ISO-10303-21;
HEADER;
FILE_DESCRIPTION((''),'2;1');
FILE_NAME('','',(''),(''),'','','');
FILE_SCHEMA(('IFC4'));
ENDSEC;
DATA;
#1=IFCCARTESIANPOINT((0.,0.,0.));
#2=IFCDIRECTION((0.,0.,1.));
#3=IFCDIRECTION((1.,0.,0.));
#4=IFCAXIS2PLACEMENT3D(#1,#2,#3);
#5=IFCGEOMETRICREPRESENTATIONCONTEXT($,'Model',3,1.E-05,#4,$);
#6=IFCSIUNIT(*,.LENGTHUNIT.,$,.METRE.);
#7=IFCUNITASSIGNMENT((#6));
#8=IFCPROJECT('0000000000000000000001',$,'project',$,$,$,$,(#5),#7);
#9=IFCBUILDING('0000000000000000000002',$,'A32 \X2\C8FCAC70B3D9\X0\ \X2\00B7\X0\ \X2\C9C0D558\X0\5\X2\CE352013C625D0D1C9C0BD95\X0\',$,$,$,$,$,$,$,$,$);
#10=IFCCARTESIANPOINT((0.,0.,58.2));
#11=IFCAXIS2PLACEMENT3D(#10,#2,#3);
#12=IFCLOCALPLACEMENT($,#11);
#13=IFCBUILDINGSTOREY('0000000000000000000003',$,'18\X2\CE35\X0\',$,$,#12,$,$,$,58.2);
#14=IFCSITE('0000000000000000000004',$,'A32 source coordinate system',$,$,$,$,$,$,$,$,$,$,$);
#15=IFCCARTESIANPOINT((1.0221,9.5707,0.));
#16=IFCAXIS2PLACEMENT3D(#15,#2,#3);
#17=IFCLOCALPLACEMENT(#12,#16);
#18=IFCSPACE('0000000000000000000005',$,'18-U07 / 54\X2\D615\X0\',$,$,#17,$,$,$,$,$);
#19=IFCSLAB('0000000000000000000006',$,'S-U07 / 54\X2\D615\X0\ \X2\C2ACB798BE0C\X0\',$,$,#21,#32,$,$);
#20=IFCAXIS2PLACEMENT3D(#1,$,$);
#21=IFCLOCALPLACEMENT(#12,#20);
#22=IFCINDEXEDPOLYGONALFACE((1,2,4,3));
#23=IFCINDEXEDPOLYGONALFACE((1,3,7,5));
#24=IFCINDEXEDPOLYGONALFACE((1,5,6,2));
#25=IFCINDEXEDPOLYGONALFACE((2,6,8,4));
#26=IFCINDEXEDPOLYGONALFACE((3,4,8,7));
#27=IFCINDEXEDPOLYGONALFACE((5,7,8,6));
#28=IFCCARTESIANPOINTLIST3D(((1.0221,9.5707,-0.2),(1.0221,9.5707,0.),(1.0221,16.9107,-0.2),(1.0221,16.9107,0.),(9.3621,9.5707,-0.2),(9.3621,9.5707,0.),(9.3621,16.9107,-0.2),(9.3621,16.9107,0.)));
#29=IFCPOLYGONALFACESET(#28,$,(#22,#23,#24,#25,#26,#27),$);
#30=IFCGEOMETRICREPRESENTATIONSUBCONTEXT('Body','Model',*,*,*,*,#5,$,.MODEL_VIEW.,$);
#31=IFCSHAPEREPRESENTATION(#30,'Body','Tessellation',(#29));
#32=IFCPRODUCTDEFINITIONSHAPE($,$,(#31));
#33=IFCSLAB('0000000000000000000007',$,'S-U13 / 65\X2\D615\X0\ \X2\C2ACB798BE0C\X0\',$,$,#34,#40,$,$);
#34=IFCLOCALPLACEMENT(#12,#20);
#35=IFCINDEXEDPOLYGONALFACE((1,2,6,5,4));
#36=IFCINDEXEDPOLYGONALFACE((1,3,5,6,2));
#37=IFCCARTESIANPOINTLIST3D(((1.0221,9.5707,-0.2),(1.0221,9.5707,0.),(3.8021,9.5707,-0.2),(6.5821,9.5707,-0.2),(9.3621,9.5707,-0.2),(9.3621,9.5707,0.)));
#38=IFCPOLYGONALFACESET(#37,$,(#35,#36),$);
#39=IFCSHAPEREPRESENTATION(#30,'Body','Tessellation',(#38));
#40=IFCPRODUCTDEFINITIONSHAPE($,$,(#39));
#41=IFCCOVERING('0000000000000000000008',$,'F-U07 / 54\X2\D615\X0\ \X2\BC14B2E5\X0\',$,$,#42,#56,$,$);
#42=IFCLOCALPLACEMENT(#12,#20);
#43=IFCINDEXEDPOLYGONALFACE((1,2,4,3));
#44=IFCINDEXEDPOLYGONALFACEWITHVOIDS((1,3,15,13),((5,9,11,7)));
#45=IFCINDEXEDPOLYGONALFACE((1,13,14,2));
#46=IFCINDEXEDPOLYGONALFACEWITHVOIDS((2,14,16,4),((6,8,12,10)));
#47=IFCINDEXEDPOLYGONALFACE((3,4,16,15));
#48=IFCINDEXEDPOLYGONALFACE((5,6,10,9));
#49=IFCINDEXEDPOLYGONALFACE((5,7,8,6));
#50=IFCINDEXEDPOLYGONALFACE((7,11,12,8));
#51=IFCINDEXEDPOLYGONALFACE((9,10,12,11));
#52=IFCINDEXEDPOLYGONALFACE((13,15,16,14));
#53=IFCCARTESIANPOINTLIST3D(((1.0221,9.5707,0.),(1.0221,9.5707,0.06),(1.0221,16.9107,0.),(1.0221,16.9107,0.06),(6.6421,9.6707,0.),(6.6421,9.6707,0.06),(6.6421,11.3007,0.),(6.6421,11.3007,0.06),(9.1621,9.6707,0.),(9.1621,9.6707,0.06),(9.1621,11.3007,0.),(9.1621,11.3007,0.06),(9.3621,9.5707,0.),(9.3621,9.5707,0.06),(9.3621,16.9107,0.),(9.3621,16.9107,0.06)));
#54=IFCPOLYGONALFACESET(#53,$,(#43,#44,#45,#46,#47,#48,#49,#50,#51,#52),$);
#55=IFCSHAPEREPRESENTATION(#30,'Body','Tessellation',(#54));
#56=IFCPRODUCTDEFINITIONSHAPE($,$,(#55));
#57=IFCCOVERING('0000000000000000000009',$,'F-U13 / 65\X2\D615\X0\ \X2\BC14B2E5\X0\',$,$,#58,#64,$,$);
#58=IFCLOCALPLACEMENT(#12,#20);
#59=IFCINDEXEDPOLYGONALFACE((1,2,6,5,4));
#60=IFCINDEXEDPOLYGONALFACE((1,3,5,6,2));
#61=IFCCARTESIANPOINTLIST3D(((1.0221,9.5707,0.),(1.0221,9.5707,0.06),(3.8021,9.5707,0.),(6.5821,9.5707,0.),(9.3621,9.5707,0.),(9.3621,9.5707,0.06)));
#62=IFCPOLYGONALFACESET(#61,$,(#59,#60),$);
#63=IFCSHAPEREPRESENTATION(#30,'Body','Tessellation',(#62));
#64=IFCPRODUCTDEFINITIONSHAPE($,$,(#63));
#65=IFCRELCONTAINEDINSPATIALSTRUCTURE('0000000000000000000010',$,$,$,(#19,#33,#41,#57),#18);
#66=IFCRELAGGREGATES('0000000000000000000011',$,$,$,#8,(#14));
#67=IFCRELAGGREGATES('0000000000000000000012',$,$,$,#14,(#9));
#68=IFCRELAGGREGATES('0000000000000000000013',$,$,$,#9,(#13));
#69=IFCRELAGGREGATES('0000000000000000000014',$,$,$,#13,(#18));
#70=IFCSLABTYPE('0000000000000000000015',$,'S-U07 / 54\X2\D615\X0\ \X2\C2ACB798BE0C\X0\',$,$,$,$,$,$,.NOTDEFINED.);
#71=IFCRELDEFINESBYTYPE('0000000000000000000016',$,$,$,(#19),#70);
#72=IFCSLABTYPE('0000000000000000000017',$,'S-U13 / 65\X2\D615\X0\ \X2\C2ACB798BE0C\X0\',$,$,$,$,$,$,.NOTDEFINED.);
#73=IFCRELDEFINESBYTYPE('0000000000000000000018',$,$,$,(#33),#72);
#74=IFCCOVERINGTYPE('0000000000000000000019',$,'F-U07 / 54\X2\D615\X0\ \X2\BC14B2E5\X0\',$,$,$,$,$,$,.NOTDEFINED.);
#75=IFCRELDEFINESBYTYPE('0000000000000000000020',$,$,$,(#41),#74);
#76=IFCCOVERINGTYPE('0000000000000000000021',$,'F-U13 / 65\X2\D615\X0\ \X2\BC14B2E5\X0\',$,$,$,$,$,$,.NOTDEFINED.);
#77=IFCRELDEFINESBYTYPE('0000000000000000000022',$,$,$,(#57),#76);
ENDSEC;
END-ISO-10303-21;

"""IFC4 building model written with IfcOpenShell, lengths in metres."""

from ifc_helpers import new_model, si_unit, frame, origin, origin_with_axes, place, context, subcontext, project, spatial, polyline, outline, extrude, source, transform, mapped, type_object, type_shapes, element, save


model = new_model("IFC4")

# Units and contexts
model_context = context("Model", 3, precision=1e-05, world=origin_with_axes())
body_context = subcontext(model_context, "Body", "Model", "MODEL_VIEW")
ifc_project = project(units=[si_unit("LENGTHUNIT", "METRE")], contexts=[model_context])

# Site, building, storey, space
storey_placement = place(None, frame((0.0, 0.0, 58.2), z_axis=(0.0, 0.0, 1.0), x_axis=(1.0, 0.0, 0.0)))
space_placement = place(storey_placement, frame((1.0221, 9.5707, 0.0), z_axis=(0.0, 0.0, 1.0), x_axis=(1.0, 0.0, 0.0)))
site = spatial("IfcSite", under=ifc_project, Name="A32 source coordinate system")
building = spatial("IfcBuilding", under=site, Name="A32 주거동 · 지하5층–옥탑지붕")
storey = spatial("IfcBuildingStorey", under=building, at=storey_placement, Name="18층", Elevation=58.2)
space = spatial("IfcSpace", under=storey, at=space_placement, Name="18-U07 / 54형")

# Slabs
slab_type_1 = type_object("IfcSlabType", Name="S-U07 / 54형 슬래브", PredefinedType="NOTDEFINED")
shared_shape_1 = source(origin(), body_context, "Body", "SweptSolid", [
    extrude(outline(polyline([(0.0, 0.0), (0.0, 7.34), (8.34, 7.34), (8.34, 0.0), (0.0, 0.0)])), frame((0.0, 0.0, -0.2)), (0.0, 0.0, 1.0), 0.2),
])
type_shapes(slab_type_1, [shared_shape_1])
slab_1_placement = place(space_placement, origin_with_axes())
element("IfcSlab", 1, at=slab_1_placement, inside=space, type_object=slab_type_1, Name="S-U07 / 54형 슬래브", context=body_context, shape_type="MappedRepresentation", body=[
    mapped(shared_shape_1, transform((0.0, 0.0, 0.0), scale=1.0)),
])
slab_type_2 = type_object("IfcSlabType", Name="S-U13 / 65형 슬래브", PredefinedType="NOTDEFINED")
shared_shape_2 = source(origin(), body_context, "Body", "SweptSolid", [
    extrude(outline(polyline([(0.0, 0.0), (8.34, 0.0), (8.34, 0.0), (0.0, 0.0), (0.0, 0.0)])), frame((0.0, 0.0, -0.2)), (0.0, 0.0, 1.0), 0.2),
])
type_shapes(slab_type_2, [shared_shape_2])
slab_2_placement = place(space_placement, origin_with_axes())
element("IfcSlab", 2, at=slab_2_placement, inside=space, type_object=slab_type_2, Name="S-U13 / 65형 슬래브", context=body_context, shape_type="MappedRepresentation", body=[
    mapped(shared_shape_2, transform((0.0, 0.0, 0.0), scale=1.0)),
])

# Coverings
covering_type_1 = type_object("IfcCoveringType", Name="F-U07 / 54형 바닥", PredefinedType="NOTDEFINED")
shared_shape_3 = source(origin(), body_context, "Body", "SweptSolid", [
    extrude(outline(polyline([(0.0, 0.0), (0.0, 7.34), (8.34, 7.34), (8.34, 0.0), (0.0, 0.0)]), holes=[polyline([(5.62, 1.73), (5.62, 0.1), (8.14, 0.1), (8.14, 1.73), (5.62, 1.73)])]), origin(), (0.0, 0.0, 1.0), 0.06),
])
type_shapes(covering_type_1, [shared_shape_3])
covering_1_placement = place(space_placement, origin_with_axes())
element("IfcCovering", 3, at=covering_1_placement, inside=space, type_object=covering_type_1, Name="F-U07 / 54형 바닥", context=body_context, shape_type="MappedRepresentation", body=[
    mapped(shared_shape_3, transform((0.0, 0.0, 0.0), scale=1.0)),
])
covering_type_2 = type_object("IfcCoveringType", Name="F-U13 / 65형 바닥", PredefinedType="NOTDEFINED")
shared_shape_4 = source(origin(), body_context, "Body", "SweptSolid", [
    extrude(outline(polyline([(0.0, 0.0), (8.34, 0.0), (8.34, 0.0), (0.0, 0.0), (0.0, 0.0)])), origin(), (0.0, 0.0, 1.0), 0.06),
])
type_shapes(covering_type_2, [shared_shape_4])
covering_2_placement = place(space_placement, origin_with_axes())
element("IfcCovering", 4, at=covering_2_placement, inside=space, type_object=covering_type_2, Name="F-U13 / 65형 바닥", context=body_context, shape_type="MappedRepresentation", body=[
    mapped(shared_shape_4, transform((0.0, 0.0, 0.0), scale=1.0)),
])

save(model, "model.ifc")
